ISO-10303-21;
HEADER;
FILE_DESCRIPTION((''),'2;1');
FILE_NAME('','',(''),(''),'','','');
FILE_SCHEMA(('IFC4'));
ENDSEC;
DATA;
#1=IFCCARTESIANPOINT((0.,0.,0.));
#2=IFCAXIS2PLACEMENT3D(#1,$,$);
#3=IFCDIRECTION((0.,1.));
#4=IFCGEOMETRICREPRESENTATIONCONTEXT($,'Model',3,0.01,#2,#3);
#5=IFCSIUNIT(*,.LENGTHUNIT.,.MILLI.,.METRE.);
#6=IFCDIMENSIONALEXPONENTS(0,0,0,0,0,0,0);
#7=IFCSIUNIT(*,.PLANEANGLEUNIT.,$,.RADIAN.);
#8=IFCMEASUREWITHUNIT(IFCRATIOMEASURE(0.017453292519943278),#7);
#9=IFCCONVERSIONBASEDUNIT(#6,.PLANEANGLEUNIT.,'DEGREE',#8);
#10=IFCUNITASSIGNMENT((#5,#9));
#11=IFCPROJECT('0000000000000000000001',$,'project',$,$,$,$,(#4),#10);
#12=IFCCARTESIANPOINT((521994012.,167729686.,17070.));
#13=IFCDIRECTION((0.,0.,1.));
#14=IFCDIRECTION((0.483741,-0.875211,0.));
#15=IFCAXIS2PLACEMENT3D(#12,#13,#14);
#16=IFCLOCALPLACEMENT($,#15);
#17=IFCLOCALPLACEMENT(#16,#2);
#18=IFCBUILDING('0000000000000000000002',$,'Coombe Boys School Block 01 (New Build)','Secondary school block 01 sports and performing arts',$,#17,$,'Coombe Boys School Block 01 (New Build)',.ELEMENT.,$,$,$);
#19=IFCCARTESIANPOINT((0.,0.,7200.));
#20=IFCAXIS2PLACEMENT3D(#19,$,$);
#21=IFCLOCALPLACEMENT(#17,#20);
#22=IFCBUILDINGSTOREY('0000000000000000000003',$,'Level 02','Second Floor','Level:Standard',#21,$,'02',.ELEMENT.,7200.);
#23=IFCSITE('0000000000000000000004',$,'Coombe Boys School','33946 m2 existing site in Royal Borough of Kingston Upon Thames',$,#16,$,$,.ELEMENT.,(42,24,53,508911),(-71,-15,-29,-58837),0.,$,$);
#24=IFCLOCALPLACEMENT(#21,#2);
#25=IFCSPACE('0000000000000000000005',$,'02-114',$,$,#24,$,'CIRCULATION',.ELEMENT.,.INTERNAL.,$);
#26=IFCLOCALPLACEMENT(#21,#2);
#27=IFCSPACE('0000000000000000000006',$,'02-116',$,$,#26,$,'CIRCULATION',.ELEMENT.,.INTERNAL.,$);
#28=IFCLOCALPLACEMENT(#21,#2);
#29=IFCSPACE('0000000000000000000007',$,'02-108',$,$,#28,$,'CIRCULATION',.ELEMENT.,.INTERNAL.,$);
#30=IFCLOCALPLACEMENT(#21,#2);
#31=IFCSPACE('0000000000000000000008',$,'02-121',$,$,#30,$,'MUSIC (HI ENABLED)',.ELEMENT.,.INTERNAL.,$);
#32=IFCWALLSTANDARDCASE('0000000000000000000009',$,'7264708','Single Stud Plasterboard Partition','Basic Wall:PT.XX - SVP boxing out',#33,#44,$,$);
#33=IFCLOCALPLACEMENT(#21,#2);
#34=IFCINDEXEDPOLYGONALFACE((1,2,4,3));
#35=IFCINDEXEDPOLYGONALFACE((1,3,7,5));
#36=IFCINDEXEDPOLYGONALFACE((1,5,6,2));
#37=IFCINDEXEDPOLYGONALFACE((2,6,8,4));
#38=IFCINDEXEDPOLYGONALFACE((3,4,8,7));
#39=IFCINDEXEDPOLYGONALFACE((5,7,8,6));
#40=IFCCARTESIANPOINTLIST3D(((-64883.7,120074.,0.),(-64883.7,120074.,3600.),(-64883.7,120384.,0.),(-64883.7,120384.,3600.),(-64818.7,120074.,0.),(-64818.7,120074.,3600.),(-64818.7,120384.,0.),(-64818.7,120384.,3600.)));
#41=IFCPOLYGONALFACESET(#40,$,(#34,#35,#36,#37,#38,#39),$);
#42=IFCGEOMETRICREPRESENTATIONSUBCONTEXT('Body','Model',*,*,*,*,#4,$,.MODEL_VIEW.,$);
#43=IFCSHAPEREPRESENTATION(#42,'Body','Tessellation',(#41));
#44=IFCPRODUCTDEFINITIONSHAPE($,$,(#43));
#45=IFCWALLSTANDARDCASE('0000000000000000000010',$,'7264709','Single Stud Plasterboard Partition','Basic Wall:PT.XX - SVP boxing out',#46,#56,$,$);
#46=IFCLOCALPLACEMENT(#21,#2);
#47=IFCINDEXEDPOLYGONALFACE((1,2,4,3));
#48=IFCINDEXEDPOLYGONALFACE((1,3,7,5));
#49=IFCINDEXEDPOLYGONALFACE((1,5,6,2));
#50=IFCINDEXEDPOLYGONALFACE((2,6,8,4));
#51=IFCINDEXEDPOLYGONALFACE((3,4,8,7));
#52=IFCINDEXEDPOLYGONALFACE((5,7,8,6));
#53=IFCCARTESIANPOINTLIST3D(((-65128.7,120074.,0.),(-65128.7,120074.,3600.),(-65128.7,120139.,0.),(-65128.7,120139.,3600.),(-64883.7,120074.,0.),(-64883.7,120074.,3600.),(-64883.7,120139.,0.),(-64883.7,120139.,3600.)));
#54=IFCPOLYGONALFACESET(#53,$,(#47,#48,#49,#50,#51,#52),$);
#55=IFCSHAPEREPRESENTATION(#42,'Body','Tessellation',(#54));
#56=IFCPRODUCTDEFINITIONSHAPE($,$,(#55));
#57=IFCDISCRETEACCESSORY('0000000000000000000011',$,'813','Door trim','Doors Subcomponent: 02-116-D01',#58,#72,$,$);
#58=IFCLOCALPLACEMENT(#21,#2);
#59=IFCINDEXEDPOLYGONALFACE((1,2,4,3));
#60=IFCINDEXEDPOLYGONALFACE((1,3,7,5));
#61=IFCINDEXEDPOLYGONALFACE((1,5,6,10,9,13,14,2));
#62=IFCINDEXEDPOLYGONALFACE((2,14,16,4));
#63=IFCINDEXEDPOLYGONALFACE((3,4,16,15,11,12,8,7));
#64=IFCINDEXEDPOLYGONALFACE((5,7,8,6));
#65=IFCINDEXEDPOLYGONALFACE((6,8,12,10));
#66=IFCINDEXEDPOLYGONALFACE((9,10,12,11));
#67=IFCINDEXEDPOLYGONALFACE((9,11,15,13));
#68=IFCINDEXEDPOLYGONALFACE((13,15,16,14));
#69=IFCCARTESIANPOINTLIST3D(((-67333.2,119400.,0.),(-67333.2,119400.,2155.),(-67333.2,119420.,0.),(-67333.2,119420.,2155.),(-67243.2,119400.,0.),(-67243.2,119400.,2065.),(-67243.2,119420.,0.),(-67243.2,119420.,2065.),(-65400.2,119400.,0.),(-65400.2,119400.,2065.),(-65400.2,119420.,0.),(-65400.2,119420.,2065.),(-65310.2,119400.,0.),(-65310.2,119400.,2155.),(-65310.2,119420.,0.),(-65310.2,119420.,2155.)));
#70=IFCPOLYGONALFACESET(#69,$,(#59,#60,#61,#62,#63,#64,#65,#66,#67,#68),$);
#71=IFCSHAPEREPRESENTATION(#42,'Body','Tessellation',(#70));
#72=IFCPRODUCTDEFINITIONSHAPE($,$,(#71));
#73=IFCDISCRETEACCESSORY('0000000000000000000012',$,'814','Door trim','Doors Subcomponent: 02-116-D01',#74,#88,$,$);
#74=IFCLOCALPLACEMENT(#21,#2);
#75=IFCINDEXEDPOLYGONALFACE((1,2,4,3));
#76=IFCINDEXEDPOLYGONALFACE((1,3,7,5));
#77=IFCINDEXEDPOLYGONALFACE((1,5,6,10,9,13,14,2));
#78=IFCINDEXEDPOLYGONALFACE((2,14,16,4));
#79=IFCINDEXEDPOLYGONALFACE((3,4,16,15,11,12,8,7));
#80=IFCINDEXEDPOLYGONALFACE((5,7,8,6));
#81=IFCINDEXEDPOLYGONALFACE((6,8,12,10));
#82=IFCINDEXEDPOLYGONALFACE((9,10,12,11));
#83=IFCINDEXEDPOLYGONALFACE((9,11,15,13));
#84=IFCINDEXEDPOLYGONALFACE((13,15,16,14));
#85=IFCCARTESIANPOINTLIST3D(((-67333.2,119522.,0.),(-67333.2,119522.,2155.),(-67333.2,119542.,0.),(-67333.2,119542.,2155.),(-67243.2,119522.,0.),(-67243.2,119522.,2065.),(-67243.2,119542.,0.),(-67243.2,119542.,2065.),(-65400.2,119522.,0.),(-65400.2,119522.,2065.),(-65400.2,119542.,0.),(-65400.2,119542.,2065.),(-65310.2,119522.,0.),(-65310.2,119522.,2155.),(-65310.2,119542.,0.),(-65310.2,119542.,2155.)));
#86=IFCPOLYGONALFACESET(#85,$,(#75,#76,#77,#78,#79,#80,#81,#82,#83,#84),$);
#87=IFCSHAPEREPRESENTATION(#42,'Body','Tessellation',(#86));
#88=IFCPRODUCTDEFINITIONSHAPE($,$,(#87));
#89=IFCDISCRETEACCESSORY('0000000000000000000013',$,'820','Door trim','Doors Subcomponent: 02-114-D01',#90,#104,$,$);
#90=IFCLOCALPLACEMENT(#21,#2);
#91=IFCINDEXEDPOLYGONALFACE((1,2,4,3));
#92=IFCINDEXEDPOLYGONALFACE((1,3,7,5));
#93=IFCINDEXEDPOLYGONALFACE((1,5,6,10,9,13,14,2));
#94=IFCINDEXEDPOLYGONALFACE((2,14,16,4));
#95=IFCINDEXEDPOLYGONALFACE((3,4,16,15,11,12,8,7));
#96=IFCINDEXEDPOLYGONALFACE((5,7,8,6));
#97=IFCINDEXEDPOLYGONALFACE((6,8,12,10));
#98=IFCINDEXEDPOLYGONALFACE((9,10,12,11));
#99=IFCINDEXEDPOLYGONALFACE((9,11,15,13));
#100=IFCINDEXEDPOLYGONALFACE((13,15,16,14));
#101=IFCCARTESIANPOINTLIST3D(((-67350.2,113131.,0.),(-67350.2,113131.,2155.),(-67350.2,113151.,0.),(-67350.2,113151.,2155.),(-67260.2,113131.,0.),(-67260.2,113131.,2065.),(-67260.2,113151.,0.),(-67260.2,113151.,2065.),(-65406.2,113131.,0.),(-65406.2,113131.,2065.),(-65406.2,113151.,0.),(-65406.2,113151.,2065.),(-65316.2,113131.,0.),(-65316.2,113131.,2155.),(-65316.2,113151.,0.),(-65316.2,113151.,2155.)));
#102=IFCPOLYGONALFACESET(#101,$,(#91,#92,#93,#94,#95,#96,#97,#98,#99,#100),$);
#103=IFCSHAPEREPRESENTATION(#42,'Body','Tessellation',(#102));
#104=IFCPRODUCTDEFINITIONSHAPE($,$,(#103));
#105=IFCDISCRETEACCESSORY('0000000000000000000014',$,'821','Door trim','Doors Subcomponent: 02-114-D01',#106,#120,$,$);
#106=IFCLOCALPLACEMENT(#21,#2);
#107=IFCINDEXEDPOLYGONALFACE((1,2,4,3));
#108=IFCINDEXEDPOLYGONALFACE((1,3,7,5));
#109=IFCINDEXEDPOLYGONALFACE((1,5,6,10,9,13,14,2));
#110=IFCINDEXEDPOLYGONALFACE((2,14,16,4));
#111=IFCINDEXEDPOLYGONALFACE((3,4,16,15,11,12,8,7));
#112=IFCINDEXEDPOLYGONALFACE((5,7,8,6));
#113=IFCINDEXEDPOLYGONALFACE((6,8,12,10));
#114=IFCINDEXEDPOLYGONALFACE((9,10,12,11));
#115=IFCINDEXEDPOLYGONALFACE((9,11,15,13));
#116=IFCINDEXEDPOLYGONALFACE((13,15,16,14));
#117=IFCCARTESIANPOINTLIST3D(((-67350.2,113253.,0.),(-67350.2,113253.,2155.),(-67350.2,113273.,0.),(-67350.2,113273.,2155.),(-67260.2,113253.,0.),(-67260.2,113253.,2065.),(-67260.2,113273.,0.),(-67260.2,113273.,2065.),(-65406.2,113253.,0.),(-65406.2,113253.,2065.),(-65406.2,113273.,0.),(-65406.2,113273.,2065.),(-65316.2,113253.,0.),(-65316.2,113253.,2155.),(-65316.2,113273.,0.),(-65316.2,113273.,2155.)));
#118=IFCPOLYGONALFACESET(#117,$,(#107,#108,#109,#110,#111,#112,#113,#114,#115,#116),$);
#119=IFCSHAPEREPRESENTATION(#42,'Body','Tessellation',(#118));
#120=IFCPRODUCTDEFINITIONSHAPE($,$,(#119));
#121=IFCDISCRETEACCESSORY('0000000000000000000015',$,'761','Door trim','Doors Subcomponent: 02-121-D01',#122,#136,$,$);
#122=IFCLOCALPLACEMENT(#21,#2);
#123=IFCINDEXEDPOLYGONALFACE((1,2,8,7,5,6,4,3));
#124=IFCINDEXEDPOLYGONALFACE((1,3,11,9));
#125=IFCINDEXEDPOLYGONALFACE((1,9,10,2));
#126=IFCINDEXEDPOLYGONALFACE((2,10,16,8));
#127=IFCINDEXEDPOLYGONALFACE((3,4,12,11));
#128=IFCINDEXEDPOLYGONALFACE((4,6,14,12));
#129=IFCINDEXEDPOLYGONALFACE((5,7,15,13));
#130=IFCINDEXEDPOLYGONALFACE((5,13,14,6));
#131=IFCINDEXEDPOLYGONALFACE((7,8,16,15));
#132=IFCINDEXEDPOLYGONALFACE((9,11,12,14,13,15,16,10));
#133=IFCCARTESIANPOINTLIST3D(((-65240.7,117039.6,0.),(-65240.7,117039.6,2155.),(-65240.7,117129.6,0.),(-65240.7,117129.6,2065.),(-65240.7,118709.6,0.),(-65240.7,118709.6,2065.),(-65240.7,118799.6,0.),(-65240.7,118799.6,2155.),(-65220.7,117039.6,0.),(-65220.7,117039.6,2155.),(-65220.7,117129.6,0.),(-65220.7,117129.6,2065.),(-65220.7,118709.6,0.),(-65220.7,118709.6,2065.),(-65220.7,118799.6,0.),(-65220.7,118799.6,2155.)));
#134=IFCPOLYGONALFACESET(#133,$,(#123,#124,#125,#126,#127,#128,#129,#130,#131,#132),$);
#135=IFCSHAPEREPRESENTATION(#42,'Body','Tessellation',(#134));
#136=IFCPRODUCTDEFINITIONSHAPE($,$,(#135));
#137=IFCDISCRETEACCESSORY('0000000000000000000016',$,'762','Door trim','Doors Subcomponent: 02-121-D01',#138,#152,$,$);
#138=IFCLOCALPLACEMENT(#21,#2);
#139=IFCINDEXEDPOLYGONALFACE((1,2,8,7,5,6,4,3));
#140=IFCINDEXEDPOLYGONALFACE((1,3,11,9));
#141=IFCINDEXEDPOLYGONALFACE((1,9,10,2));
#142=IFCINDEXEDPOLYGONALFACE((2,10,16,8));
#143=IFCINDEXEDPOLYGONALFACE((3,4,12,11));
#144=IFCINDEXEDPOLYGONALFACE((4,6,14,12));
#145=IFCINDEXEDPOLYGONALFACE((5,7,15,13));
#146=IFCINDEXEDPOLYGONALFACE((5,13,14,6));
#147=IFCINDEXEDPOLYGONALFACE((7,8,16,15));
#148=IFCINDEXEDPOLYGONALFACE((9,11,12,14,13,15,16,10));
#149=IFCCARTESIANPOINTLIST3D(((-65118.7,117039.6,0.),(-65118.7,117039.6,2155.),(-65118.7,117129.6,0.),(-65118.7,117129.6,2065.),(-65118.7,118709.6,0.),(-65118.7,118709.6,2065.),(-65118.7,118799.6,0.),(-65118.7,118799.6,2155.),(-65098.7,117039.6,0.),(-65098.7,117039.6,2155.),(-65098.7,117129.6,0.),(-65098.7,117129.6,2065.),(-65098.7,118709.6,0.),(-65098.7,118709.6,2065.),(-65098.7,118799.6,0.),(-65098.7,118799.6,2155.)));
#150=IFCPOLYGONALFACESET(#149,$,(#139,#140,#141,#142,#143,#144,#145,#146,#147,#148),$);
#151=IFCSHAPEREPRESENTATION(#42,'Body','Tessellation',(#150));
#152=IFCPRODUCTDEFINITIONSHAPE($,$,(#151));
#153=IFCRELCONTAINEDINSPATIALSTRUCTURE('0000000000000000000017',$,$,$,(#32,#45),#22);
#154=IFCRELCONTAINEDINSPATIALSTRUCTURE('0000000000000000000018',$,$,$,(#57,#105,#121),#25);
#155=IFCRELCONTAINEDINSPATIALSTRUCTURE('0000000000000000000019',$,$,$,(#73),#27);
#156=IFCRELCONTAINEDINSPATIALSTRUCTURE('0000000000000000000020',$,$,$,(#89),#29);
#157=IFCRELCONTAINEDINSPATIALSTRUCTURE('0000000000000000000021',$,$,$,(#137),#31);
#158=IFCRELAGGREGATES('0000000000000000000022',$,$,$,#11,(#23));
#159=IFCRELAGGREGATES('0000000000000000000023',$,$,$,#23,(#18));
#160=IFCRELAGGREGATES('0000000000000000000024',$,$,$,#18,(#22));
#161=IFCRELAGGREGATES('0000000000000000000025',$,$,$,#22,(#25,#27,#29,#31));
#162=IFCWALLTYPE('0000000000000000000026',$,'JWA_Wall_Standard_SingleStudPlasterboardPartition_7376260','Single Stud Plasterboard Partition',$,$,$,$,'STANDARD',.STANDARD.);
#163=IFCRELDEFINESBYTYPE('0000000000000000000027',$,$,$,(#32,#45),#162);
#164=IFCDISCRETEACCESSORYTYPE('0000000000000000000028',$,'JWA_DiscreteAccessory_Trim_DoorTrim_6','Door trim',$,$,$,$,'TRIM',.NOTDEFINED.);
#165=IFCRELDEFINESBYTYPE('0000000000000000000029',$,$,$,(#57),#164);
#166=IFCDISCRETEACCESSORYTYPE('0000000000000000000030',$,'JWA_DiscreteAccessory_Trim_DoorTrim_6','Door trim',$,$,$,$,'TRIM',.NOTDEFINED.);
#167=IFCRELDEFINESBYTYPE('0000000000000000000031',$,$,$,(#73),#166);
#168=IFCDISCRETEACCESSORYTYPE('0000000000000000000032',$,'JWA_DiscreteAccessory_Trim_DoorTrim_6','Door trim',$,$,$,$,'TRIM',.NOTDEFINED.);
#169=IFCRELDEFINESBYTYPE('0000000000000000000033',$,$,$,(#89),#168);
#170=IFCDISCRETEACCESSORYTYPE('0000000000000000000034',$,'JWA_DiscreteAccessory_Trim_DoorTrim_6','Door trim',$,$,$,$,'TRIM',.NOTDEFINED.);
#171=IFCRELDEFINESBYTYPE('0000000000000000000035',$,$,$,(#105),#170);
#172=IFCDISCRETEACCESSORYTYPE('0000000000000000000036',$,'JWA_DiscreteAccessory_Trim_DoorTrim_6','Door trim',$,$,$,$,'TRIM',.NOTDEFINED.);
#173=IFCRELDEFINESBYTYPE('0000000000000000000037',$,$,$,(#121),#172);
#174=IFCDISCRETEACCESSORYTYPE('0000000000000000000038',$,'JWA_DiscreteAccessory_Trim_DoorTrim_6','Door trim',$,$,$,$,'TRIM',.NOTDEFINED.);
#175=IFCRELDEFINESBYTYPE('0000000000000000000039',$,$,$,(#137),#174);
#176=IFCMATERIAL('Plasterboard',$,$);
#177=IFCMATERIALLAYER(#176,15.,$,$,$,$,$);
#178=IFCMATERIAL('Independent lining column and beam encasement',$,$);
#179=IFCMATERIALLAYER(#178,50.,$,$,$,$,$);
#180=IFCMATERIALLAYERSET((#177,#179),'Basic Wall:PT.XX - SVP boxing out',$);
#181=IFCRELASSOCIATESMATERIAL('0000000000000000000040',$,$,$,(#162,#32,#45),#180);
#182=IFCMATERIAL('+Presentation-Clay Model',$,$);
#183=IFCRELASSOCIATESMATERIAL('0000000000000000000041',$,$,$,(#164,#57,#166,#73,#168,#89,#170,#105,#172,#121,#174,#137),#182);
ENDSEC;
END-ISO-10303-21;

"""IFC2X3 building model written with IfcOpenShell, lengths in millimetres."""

from ifc_helpers import new_model, entity, si_unit, converted_unit, direction, frame, frame_2d, origin, place, context, subcontext, project, spatial, polyline, rectangle, outline, extrude, source, transform, mapped, material, layer, layer_set, layer_usage, type_object, type_shapes, element, save


model = new_model("IFC2X3")

# Units and contexts
model_context = context("Model", 3, precision=0.01, world=origin(), true_north=direction((0.0, 1.0)))
body_context = subcontext(model_context, "Body", "Model", "MODEL_VIEW")
ifc_project = project(units=[si_unit("LENGTHUNIT", "METRE", prefix="MILLI"), converted_unit("PLANEANGLEUNIT", "DEGREE", entity("IfcRatioMeasure", 0.017453292519943278), si_unit("PLANEANGLEUNIT", "RADIAN"), dimensions=[0, 0, 0, 0, 0, 0, 0])], contexts=[model_context])

# Site, building, storey
site_placement = place(None, frame((521994012.0, 167729686.0, 17070.0), z_axis=(0.0, 0.0, 1.0), x_axis=(0.483741, -0.875211, 0.0)))
site = spatial("IfcSite", under=ifc_project, at=site_placement, Name="Coombe Boys School", Description="33946 m2 existing site in Royal Borough of Kingston Upon Thames", CompositionType="ELEMENT", RefLatitude=(42, 24, 53, 508911), RefLongitude=(-71, -15, -29, -58837), RefElevation=0.0)
building_placement = place(site_placement, origin())
building = spatial("IfcBuilding", under=site, at=building_placement, Name="Coombe Boys School Block 01 (New Build)", Description="Secondary school block 01 sports and performing arts", LongName="Coombe Boys School Block 01 (New Build)", CompositionType="ELEMENT")
storey_placement = place(building_placement, frame((0.0, 0.0, 7200.0)))
storey = spatial("IfcBuildingStorey", under=building, at=storey_placement, Name="Level 02", Description="Second Floor", ObjectType="Level:Standard", LongName="02", CompositionType="ELEMENT", Elevation=7200.0)

# Shared definitions
ifc_material_1 = material(Name="Plasterboard")

# Shared definitions
ifc_material_2 = material(Name="Independent lining column and beam encasement")

# Walls
ifc_layer_1 = layer(ifc_material_1, 15.0)
ifc_layer_2 = layer(ifc_material_2, 50.0)
ifc_layer_set_1 = layer_set([ifc_layer_1, ifc_layer_2], Name="Basic Wall:PT.XX - SVP boxing out")
ifc_layer_usage_1 = layer_usage(ifc_layer_set_1, "AXIS2", "NEGATIVE", 32.5)
wall_type_1 = type_object("IfcWallType", Name="JWA_Wall_Standard_SingleStudPlasterboardPartition_7376260", Description="Single Stud Plasterboard Partition", ElementType="STANDARD", PredefinedType="STANDARD", material=ifc_layer_set_1)
wall_1_placement = place(storey_placement, frame((-64851.2, 120384.0, 0.0), z_axis=(0.0, 0.0, 1.0), x_axis=(0.0, -1.0, 0.0)))
element("IfcWallStandardCase", 1, at=wall_1_placement, inside=storey, type_object=wall_type_1, material=ifc_layer_usage_1, Name="7264708", Description="Single Stud Plasterboard Partition", ObjectType="Basic Wall:PT.XX - SVP boxing out", context=body_context, shape_type="SweptSolid", body=[
    extrude(rectangle(XDim=310.0, YDim=65.0, at=frame_2d((155.0, 0.0), x_axis=(-1.0, 0.0))), origin(), (0.0, 0.0, 1.0), 3600.0),
])
wall_2_placement = place(storey_placement, frame((-64883.7, 120106.5, 0.0), z_axis=(0.0, 0.0, 1.0), x_axis=(-1.0, 0.0, 0.0)))
element("IfcWallStandardCase", 2, at=wall_2_placement, inside=storey, type_object=wall_type_1, material=ifc_layer_usage_1, Name="7264709", Description="Single Stud Plasterboard Partition", ObjectType="Basic Wall:PT.XX - SVP boxing out", context=body_context, shape_type="SweptSolid", body=[
    extrude(rectangle(XDim=245.0, YDim=65.0, at=frame_2d((122.5, 0.0), x_axis=(-1.0, 0.0))), origin(), (0.0, 0.0, 1.0), 3600.0),
])

# Shared definitions
ifc_material_3 = material(Name="+Presentation-Clay Model")

# Shared definitions
space_1_placement = place(storey_placement, origin())
space_1 = spatial("IfcSpace", under=storey, at=space_1_placement, Name="02-114", LongName="CIRCULATION", CompositionType="ELEMENT", InteriorOrExteriorSpace="INTERNAL")

# Discrete accessory
discrete_accessory_type_1 = type_object("IfcDiscreteAccessoryType", Name="JWA_DiscreteAccessory_Trim_DoorTrim_6", Description="Door trim", ElementType="TRIM", material=ifc_material_3)
shared_shape_1 = source(origin(), body_context, "Body", "SweptSolid", [
    extrude(outline(polyline([(-1055.0, -1011.5), (1100.0, -1011.5), (1100.0, 1011.5), (-1055.0, 1011.5), (-1055.0, 921.5), (1010.0, 921.5), (1010.0, -921.5), (-1055.0, -921.5), (-1055.0, -1011.5)])), frame((0.0, -20.0, 1055.0), z_axis=(0.0, 1.0, 0.0), x_axis=(0.0, 0.0, 1.0)), (0.0, 0.0, 1.0), 20.0),
])
type_shapes(discrete_accessory_type_1, [shared_shape_1])
discrete_accessory_1_placement = place(space_1_placement, frame((-66321.7, 119420.0, 0.0)))
element("IfcDiscreteAccessory", 3, at=discrete_accessory_1_placement, inside=space_1, type_object=discrete_accessory_type_1, material=ifc_material_3, Name="813", Description="Door trim", ObjectType="Doors Subcomponent: 02-116-D01", context=body_context, shape_type="MappedRepresentation", body=[
    mapped(shared_shape_1, transform((0.0, 0.0, 0.0), scale=1.0)),
])

# Shared definitions
space_2_placement = place(storey_placement, origin())
space_2 = spatial("IfcSpace", under=storey, at=space_2_placement, Name="02-116", LongName="CIRCULATION", CompositionType="ELEMENT", InteriorOrExteriorSpace="INTERNAL")

# Discrete accessory
discrete_accessory_type_2 = type_object("IfcDiscreteAccessoryType", Name="JWA_DiscreteAccessory_Trim_DoorTrim_6", Description="Door trim", ElementType="TRIM", material=ifc_material_3)
shared_shape_2 = source(origin(), body_context, "Body", "SweptSolid", [
    extrude(outline(polyline([(921.5, -1055.0), (1011.5, -1055.0), (1011.5, 1100.0), (-1011.5, 1100.0), (-1011.5, -1055.0), (-921.5, -1055.0), (-921.5, 1010.0), (921.5, 1010.0), (921.5, -1055.0)])), frame((0.0, 0.0, 1055.0), z_axis=(0.0, 1.0, 0.0), x_axis=(-1.0, 0.0, 0.0)), (0.0, 0.0, 1.0), 20.0),
])
type_shapes(discrete_accessory_type_2, [shared_shape_2])
discrete_accessory_2_placement = place(space_2_placement, frame((-66321.7, 119522.0, 0.0)))
element("IfcDiscreteAccessory", 4, at=discrete_accessory_2_placement, inside=space_2, type_object=discrete_accessory_type_2, material=ifc_material_3, Name="814", Description="Door trim", ObjectType="Doors Subcomponent: 02-116-D01", context=body_context, shape_type="MappedRepresentation", body=[
    mapped(shared_shape_2, transform((0.0, 0.0, 0.0), scale=1.0)),
])

# Shared definitions
space_3_placement = place(storey_placement, origin())
space_3 = spatial("IfcSpace", under=storey, at=space_3_placement, Name="02-108", LongName="CIRCULATION", CompositionType="ELEMENT", InteriorOrExteriorSpace="INTERNAL")

# Discrete accessories
discrete_accessory_type_3 = type_object("IfcDiscreteAccessoryType", Name="JWA_DiscreteAccessory_Trim_DoorTrim_6", Description="Door trim", ElementType="TRIM", material=ifc_material_3)
shared_shape_3 = source(origin(), body_context, "Body", "SweptSolid", [
    extrude(outline(polyline([(-1055.0, -1017.0), (1100.0, -1017.0), (1100.0, 1017.0), (-1055.0, 1017.0), (-1055.0, 927.0), (1010.0, 927.0), (1010.0, -927.0), (-1055.0, -927.0), (-1055.0, -1017.0)])), frame((0.0, -20.0, 1055.0), z_axis=(0.0, 1.0, 0.0), x_axis=(0.0, 0.0, 1.0)), (0.0, 0.0, 1.0), 20.0),
])
type_shapes(discrete_accessory_type_3, [shared_shape_3])
discrete_accessory_3_placement = place(space_3_placement, frame((-66333.2, 113151.0, 0.0)))
element("IfcDiscreteAccessory", 5, at=discrete_accessory_3_placement, inside=space_3, type_object=discrete_accessory_type_3, material=ifc_material_3, Name="820", Description="Door trim", ObjectType="Doors Subcomponent: 02-114-D01", context=body_context, shape_type="MappedRepresentation", body=[
    mapped(shared_shape_3, transform((0.0, 0.0, 0.0), scale=1.0)),
])
discrete_accessory_type_4 = type_object("IfcDiscreteAccessoryType", Name="JWA_DiscreteAccessory_Trim_DoorTrim_6", Description="Door trim", ElementType="TRIM", material=ifc_material_3)
shared_shape_4 = source(origin(), body_context, "Body", "SweptSolid", [
    extrude(outline(polyline([(927.0, -1055.0), (1017.0, -1055.0), (1017.0, 1100.0), (-1017.0, 1100.0), (-1017.0, -1055.0), (-927.0, -1055.0), (-927.0, 1010.0), (927.0, 1010.0), (927.0, -1055.0)])), frame((0.0, 0.0, 1055.0), z_axis=(0.0, 1.0, 0.0), x_axis=(-1.0, 0.0, 0.0)), (0.0, 0.0, 1.0), 20.0),
])
type_shapes(discrete_accessory_type_4, [shared_shape_4])
discrete_accessory_4_placement = place(space_1_placement, frame((-66333.2, 113253.0, 0.0)))
element("IfcDiscreteAccessory", 6, at=discrete_accessory_4_placement, inside=space_1, type_object=discrete_accessory_type_4, material=ifc_material_3, Name="821", Description="Door trim", ObjectType="Doors Subcomponent: 02-114-D01", context=body_context, shape_type="MappedRepresentation", body=[
    mapped(shared_shape_4, transform((0.0, 0.0, 0.0), scale=1.0)),
])
discrete_accessory_type_5 = type_object("IfcDiscreteAccessoryType", Name="JWA_DiscreteAccessory_Trim_DoorTrim_6", Description="Door trim", ElementType="TRIM", material=ifc_material_3)
shared_shape_5 = source(origin(), body_context, "Body", "SweptSolid", [
    extrude(outline(polyline([(790.0, -1055.0), (880.0, -1055.0), (880.0, 1100.0), (-880.0, 1100.0), (-880.0, -1055.0), (-790.0, -1055.0), (-790.0, 1010.0), (790.0, 1010.0), (790.0, -1055.0)])), frame((0.0, 0.0, 1055.0), z_axis=(0.0, 1.0, 0.0), x_axis=(-1.0, 0.0, 0.0)), (0.0, 0.0, 1.0), 20.0),
])
type_shapes(discrete_accessory_type_5, [shared_shape_5])
discrete_accessory_5_placement = place(space_1_placement, frame((-65220.7, 117919.6, 0.0), z_axis=(0.0, 0.0, 1.0), x_axis=(0.0, 1.0, 0.0)))
element("IfcDiscreteAccessory", 7, at=discrete_accessory_5_placement, inside=space_1, type_object=discrete_accessory_type_5, material=ifc_material_3, Name="761", Description="Door trim", ObjectType="Doors Subcomponent: 02-121-D01", context=body_context, shape_type="MappedRepresentation", body=[
    mapped(shared_shape_5, transform((0.0, 0.0, 0.0), scale=1.0)),
])

# Shared definitions
space_4_placement = place(storey_placement, origin())
space_4 = spatial("IfcSpace", under=storey, at=space_4_placement, Name="02-121", LongName="MUSIC (HI ENABLED)", CompositionType="ELEMENT", InteriorOrExteriorSpace="INTERNAL")

# Discrete accessory
discrete_accessory_type_6 = type_object("IfcDiscreteAccessoryType", Name="JWA_DiscreteAccessory_Trim_DoorTrim_6", Description="Door trim", ElementType="TRIM", material=ifc_material_3)
shared_shape_6 = source(origin(), body_context, "Body", "SweptSolid", [
    extrude(outline(polyline([(-1055.0, -880.0), (1100.0, -880.0), (1100.0, 880.0), (-1055.0, 880.0), (-1055.0, 790.0), (1010.0, 790.0), (1010.0, -790.0), (-1055.0, -790.0), (-1055.0, -880.0)])), frame((0.0, -20.0, 1055.0), z_axis=(0.0, 1.0, 0.0), x_axis=(0.0, 0.0, 1.0)), (0.0, 0.0, 1.0), 20.0),
])
type_shapes(discrete_accessory_type_6, [shared_shape_6])
discrete_accessory_6_placement = place(space_4_placement, frame((-65118.7, 117919.6, 0.0), z_axis=(0.0, 0.0, 1.0), x_axis=(0.0, 1.0, 0.0)))
element("IfcDiscreteAccessory", 8, at=discrete_accessory_6_placement, inside=space_4, type_object=discrete_accessory_type_6, material=ifc_material_3, Name="762", Description="Door trim", ObjectType="Doors Subcomponent: 02-121-D01", context=body_context, shape_type="MappedRepresentation", body=[
    mapped(shared_shape_6, transform((0.0, 0.0, 0.0), scale=1.0)),
])

save(model, "model.ifc")
